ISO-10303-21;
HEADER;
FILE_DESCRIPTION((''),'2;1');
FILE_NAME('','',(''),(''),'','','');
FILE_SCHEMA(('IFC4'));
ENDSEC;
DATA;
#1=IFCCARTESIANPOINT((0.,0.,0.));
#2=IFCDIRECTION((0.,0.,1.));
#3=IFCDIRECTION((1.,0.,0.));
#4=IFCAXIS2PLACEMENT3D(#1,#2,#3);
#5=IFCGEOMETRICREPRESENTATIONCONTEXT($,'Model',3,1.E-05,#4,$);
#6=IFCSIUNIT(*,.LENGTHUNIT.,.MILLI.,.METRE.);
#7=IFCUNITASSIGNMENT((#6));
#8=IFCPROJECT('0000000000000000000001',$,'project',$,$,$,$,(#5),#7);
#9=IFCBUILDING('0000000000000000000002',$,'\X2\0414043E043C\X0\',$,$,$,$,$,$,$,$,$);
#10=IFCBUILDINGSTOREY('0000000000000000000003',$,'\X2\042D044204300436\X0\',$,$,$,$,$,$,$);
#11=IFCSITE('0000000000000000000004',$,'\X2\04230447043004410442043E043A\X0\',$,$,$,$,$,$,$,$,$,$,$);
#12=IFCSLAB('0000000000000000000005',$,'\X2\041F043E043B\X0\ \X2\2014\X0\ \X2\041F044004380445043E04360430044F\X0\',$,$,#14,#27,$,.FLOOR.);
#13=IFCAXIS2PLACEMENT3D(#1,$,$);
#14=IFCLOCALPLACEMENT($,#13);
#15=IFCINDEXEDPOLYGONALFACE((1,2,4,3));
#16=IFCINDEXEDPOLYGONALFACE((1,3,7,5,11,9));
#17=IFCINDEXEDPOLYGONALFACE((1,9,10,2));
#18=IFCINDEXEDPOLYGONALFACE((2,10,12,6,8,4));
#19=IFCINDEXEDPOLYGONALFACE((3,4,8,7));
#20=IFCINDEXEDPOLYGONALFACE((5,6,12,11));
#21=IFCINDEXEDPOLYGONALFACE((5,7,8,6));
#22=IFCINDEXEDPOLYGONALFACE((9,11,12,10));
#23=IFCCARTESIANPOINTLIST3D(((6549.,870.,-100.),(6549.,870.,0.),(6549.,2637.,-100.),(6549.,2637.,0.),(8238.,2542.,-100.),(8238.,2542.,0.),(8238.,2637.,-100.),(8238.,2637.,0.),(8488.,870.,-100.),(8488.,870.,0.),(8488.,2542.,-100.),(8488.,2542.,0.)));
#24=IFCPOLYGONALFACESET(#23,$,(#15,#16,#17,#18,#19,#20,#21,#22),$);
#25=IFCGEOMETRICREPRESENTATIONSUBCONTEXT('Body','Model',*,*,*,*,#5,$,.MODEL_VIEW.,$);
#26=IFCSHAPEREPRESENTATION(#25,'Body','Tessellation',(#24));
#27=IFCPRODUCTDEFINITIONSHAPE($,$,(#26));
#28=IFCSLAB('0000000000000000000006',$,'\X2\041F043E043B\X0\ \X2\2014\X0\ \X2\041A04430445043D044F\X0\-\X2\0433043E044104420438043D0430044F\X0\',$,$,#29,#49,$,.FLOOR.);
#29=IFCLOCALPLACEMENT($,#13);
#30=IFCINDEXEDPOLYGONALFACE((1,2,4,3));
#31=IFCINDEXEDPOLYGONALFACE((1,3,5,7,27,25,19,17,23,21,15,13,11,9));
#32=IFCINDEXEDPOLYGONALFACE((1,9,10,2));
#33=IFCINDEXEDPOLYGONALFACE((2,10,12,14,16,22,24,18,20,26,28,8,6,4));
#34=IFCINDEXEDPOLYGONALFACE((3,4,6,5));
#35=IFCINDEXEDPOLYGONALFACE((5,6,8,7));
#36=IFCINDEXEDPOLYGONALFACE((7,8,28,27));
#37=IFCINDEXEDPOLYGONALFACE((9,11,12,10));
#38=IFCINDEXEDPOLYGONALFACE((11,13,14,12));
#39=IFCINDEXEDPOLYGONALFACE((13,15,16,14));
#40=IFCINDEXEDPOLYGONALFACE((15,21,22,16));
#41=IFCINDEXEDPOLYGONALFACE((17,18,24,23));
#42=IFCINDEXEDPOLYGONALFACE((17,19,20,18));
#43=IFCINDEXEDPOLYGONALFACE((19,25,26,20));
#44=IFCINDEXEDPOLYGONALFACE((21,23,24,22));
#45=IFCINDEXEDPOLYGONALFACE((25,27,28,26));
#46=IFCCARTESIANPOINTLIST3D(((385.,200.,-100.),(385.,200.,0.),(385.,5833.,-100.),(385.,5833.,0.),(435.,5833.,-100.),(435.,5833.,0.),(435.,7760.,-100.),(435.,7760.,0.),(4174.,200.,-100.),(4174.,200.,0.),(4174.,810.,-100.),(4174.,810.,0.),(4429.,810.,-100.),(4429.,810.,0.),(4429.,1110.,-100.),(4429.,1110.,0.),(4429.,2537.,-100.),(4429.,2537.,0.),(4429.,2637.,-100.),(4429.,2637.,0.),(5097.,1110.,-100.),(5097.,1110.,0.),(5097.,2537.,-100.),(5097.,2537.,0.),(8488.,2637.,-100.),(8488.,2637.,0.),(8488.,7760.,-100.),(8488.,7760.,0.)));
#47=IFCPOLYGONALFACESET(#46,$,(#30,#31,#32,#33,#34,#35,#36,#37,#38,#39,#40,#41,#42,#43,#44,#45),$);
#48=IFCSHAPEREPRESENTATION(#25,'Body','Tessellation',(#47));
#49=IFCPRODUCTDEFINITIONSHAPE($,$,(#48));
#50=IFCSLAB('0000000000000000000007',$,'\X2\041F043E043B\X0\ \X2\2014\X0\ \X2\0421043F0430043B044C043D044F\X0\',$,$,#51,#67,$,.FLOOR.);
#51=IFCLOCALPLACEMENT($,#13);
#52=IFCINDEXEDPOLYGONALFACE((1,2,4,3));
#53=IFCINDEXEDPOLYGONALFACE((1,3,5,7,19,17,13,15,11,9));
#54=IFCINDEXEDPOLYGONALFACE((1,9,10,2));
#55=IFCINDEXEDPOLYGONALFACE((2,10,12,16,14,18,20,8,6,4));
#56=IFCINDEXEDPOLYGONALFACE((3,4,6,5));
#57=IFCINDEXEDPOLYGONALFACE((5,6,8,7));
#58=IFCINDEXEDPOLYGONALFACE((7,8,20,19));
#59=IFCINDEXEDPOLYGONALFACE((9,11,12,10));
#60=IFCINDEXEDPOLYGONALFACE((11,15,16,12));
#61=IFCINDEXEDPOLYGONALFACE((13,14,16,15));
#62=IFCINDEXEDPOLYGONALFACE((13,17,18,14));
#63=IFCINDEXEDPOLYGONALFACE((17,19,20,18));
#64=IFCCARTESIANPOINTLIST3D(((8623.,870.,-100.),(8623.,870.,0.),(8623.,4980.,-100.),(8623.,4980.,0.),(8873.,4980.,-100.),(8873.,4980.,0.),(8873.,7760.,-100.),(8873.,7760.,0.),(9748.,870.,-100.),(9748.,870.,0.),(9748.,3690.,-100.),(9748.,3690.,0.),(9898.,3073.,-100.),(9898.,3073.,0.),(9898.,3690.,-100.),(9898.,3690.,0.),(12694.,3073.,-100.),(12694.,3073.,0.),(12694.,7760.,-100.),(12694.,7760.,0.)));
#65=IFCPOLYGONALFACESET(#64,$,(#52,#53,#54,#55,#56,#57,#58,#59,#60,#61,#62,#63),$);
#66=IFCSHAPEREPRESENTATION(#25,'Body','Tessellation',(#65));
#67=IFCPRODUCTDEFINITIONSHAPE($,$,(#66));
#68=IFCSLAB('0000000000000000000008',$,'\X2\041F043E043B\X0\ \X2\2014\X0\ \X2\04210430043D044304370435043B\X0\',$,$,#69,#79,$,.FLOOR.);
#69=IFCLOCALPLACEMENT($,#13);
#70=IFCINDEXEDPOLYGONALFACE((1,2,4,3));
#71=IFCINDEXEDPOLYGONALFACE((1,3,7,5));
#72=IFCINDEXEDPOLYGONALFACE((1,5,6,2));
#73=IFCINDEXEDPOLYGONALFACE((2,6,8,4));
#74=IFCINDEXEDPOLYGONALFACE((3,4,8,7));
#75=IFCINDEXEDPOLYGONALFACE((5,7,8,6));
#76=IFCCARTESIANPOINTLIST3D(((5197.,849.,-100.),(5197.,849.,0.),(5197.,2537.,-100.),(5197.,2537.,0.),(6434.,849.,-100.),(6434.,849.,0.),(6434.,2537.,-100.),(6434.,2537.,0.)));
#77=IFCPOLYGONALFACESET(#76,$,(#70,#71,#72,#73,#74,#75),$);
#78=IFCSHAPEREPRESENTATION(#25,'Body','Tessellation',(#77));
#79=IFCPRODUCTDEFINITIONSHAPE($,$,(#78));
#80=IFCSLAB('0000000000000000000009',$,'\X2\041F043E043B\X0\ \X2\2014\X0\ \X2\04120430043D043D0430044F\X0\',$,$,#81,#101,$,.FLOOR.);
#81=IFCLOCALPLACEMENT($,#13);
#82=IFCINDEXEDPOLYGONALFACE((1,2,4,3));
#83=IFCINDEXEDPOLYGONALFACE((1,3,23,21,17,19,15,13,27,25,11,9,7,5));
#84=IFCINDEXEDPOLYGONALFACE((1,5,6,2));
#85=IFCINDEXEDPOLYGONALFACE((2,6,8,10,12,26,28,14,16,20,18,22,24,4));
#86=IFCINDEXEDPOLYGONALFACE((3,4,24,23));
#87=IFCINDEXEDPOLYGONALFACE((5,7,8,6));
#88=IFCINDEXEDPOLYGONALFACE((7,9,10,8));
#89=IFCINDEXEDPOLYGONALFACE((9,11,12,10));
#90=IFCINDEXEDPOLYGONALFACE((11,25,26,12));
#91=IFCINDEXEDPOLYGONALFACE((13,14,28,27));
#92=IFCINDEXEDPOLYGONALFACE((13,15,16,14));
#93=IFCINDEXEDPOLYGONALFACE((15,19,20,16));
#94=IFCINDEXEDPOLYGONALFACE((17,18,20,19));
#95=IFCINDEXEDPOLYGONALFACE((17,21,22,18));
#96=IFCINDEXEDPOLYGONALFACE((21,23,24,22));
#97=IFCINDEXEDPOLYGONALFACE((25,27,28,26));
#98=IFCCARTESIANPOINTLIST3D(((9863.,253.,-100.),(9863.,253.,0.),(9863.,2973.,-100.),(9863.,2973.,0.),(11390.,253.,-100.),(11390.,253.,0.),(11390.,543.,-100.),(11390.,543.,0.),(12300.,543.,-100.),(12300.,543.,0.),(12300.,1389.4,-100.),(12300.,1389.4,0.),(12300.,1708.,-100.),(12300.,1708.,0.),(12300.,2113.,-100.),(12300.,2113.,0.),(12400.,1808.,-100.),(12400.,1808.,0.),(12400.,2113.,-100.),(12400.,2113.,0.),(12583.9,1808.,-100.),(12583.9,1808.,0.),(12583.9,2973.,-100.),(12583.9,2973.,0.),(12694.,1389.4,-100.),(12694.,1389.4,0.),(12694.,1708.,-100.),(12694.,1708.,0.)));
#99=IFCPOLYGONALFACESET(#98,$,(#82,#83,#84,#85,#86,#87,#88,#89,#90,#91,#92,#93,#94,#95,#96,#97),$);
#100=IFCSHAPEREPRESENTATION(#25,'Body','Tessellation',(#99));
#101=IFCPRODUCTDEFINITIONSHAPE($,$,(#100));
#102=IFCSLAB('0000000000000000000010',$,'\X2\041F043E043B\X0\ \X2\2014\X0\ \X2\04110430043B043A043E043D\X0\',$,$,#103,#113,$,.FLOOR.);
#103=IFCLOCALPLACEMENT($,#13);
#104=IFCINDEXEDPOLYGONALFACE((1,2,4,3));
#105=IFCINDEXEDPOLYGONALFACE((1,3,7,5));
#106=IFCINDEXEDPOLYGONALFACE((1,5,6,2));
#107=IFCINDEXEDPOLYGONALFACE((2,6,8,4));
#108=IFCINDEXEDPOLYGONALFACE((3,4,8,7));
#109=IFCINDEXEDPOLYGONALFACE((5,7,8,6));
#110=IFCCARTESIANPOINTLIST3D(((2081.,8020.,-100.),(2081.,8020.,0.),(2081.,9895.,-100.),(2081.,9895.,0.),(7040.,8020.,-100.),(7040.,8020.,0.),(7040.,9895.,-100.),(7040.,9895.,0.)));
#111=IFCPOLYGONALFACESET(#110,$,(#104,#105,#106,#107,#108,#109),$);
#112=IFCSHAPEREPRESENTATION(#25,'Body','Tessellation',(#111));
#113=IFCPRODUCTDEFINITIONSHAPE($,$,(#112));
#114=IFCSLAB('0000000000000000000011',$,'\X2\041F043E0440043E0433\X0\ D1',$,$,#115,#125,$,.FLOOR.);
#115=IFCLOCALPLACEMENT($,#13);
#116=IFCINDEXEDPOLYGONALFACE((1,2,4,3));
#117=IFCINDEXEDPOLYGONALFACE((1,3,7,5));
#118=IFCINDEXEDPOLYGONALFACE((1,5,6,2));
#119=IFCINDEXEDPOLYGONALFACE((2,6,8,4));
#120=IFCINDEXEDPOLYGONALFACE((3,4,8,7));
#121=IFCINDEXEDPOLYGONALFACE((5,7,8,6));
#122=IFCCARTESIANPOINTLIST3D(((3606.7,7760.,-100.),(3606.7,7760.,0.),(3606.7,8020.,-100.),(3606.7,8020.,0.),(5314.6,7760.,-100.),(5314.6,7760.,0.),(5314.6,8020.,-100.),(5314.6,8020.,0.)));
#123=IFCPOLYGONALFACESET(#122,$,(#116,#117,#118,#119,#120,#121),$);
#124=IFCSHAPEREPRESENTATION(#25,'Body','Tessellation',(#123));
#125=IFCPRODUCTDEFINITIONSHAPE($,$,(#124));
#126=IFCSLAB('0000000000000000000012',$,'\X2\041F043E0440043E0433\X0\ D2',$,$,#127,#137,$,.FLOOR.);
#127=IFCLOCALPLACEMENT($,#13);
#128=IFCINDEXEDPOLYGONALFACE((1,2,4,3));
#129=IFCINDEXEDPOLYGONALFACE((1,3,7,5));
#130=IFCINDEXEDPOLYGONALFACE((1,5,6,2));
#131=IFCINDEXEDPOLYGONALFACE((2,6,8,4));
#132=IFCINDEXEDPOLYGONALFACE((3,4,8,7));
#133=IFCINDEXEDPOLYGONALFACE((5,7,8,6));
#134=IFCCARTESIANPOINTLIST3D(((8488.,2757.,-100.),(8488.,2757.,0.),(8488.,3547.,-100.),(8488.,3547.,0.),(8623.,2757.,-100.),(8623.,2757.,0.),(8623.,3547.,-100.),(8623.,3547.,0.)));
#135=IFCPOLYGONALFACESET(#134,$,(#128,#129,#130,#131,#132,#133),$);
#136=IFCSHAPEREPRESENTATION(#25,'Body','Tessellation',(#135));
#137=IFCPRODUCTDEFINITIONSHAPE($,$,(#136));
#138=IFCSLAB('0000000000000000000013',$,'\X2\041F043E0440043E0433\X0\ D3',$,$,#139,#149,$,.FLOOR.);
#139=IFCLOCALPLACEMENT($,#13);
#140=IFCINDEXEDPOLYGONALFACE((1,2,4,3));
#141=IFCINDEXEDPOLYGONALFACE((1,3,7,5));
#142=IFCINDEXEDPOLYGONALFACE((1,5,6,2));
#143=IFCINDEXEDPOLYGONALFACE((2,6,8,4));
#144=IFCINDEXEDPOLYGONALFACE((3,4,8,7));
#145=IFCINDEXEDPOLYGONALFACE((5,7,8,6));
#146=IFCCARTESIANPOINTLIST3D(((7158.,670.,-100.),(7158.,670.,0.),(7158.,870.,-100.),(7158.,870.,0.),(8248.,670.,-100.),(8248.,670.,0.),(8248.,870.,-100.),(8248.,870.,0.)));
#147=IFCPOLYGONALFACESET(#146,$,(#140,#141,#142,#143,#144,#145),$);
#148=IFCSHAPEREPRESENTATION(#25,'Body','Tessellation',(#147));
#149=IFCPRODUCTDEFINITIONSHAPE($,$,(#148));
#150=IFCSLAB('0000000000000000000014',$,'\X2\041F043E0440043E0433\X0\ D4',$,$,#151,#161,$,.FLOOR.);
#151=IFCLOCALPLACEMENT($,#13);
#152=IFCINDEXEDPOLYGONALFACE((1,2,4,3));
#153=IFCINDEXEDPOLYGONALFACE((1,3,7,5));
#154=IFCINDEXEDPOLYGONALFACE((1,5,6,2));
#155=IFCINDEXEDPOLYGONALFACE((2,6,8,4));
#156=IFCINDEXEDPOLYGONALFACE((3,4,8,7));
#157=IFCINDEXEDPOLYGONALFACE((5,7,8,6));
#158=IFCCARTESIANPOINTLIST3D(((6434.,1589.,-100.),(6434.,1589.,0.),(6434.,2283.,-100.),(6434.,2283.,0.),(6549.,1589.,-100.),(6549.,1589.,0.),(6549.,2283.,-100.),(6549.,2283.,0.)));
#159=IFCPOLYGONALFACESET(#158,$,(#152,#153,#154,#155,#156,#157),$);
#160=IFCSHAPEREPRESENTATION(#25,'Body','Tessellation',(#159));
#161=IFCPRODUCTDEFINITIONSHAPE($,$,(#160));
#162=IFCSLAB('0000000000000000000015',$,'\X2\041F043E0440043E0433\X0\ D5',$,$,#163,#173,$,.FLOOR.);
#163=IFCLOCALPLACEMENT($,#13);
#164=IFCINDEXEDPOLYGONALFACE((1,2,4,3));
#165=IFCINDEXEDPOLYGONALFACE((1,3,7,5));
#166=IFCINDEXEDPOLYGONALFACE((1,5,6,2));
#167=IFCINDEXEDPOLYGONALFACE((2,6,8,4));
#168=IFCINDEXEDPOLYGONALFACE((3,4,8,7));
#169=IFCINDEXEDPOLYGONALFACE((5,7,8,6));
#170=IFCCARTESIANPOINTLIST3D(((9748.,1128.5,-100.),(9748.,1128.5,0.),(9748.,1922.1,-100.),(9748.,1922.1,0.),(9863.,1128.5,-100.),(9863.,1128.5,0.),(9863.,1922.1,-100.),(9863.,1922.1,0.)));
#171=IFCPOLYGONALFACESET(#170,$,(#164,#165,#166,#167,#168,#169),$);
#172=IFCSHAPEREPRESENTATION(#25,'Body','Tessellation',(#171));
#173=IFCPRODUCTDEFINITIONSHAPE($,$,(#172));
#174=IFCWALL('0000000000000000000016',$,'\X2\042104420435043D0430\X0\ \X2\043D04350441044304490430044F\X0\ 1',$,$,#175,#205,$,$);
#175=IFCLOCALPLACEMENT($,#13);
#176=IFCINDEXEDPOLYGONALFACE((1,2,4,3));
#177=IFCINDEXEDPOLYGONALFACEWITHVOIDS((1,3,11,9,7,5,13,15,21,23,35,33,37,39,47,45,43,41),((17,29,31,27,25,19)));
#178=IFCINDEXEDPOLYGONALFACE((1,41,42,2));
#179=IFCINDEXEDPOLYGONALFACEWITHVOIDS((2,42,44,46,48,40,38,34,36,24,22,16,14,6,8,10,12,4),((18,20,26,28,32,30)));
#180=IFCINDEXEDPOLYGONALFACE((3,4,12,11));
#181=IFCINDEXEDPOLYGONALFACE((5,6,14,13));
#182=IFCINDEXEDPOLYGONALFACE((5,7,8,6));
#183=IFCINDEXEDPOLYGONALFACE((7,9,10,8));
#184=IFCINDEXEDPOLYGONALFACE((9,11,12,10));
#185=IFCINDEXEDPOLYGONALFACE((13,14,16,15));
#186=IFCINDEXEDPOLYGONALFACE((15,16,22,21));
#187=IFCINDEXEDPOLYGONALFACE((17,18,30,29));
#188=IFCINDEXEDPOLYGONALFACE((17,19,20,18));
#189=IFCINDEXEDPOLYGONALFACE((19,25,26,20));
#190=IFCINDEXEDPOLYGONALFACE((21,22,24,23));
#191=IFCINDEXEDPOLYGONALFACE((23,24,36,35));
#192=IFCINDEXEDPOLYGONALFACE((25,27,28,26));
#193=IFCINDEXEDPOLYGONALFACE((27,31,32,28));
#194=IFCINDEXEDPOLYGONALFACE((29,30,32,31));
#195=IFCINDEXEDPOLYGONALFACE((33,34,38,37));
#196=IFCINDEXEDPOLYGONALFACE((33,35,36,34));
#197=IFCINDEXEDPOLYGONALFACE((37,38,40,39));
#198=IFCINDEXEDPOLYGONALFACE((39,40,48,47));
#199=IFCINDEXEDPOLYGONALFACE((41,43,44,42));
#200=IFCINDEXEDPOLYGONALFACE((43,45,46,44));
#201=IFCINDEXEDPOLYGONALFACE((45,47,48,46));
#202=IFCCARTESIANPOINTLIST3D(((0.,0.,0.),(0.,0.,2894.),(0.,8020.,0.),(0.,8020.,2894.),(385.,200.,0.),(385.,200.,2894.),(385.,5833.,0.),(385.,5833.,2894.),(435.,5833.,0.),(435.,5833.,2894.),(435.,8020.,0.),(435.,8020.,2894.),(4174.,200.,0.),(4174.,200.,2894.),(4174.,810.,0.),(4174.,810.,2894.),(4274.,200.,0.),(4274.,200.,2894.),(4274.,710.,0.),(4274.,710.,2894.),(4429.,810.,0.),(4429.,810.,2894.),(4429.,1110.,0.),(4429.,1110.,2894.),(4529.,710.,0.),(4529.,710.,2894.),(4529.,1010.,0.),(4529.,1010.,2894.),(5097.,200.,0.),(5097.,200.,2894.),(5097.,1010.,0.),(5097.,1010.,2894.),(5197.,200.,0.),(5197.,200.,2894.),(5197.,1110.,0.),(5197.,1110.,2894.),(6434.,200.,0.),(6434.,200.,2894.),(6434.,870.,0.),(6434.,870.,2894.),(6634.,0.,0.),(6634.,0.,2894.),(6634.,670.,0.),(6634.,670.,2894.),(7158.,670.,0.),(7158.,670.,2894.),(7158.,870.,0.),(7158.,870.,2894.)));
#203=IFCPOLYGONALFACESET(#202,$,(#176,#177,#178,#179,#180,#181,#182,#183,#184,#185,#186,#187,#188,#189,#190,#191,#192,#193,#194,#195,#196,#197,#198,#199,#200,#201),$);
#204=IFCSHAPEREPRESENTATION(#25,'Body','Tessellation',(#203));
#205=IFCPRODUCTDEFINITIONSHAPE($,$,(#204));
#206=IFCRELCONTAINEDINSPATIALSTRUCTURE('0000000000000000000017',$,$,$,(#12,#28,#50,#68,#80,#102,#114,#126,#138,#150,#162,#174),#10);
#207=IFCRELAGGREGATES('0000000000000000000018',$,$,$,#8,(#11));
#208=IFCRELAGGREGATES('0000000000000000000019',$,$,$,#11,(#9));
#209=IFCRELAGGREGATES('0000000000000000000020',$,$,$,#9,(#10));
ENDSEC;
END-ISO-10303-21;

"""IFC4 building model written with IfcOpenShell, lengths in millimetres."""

from ifc_helpers import new_model, si_unit, frame, origin, origin_with_axes, place, context, subcontext, project, spatial, polyline, outline, extrude, element, save


model = new_model("IFC4")

# Units and contexts
model_context = context("Model", 3, precision=1e-05, world=origin_with_axes())
body_context = subcontext(model_context, "Body", "Model", "MODEL_VIEW")
ifc_project = project(units=[si_unit("LENGTHUNIT", "METRE", prefix="MILLI")], contexts=[model_context])

# Site, building, storey
site = spatial("IfcSite", under=ifc_project, Name="Участок")
building = spatial("IfcBuilding", under=site, Name="Дом")
storey = spatial("IfcBuildingStorey", under=building, Name="Этаж")

# Slabs
slab_1_placement = place(None, frame((0.0, 0.0, -100.0), z_axis=(0.0, 0.0, 1.0), x_axis=(1.0, 0.0, 0.0)))
element("IfcSlab", 1, at=slab_1_placement, inside=storey, Name="Пол — Прихожая", PredefinedType="FLOOR", context=body_context, shape_type="SweptSolid", body=[
    extrude(outline(polyline([(8238.0, 2637.0), (8238.0, 2542.0), (8488.0, 2542.0), (8488.0, 870.0), (6549.0, 870.0), (6549.0, 2637.0), (8238.0, 2637.0)])), origin(), (0.0, 0.0, 1.0), 100.0),
])
slab_2_placement = place(None, frame((0.0, 0.0, -100.0), z_axis=(0.0, 0.0, 1.0), x_axis=(1.0, 0.0, 0.0)))
element("IfcSlab", 2, at=slab_2_placement, inside=storey, Name="Пол — Кухня-гостиная", PredefinedType="FLOOR", context=body_context, shape_type="SweptSolid", body=[
    extrude(outline(polyline([(435.0, 7760.0), (8488.0, 7760.0), (8488.0, 2637.0), (4429.0, 2637.0), (4429.0, 2537.0), (5097.0, 2537.0), (5097.0, 1110.0), (4429.0, 1110.0), (4429.0, 810.0), (4174.0, 810.0), (4174.0, 200.0), (385.0, 200.0), (385.0, 5833.0), (435.0, 5833.0), (435.0, 7760.0)])), origin(), (0.0, 0.0, 1.0), 100.0),
])
slab_3_placement = place(None, frame((0.0, 0.0, -100.0), z_axis=(0.0, 0.0, 1.0), x_axis=(1.0, 0.0, 0.0)))
element("IfcSlab", 3, at=slab_3_placement, inside=storey, Name="Пол — Спальня", PredefinedType="FLOOR", context=body_context, shape_type="SweptSolid", body=[
    extrude(outline(polyline([(9748.0, 3690.0), (9748.0, 870.0), (8623.0, 870.0), (8623.0, 4980.0), (8873.0, 4980.0), (8873.0, 7760.0), (12694.0, 7760.0), (12694.0, 3073.0), (9898.0, 3073.0), (9898.0, 3690.0), (9748.0, 3690.0)])), origin(), (0.0, 0.0, 1.0), 100.0),
])
slab_4_placement = place(None, frame((0.0, 0.0, -100.0), z_axis=(0.0, 0.0, 1.0), x_axis=(1.0, 0.0, 0.0)))
element("IfcSlab", 4, at=slab_4_placement, inside=storey, Name="Пол — Санузел", PredefinedType="FLOOR", context=body_context, shape_type="SweptSolid", body=[
    extrude(outline(polyline([(5197.0, 2537.0), (6434.0, 2537.0), (6434.0, 849.0), (5197.0, 849.0), (5197.0, 2537.0)])), origin(), (0.0, 0.0, 1.0), 100.0),
])
slab_5_placement = place(None, frame((0.0, 0.0, -100.0), z_axis=(0.0, 0.0, 1.0), x_axis=(1.0, 0.0, 0.0)))
element("IfcSlab", 5, at=slab_5_placement, inside=storey, Name="Пол — Ванная", PredefinedType="FLOOR", context=body_context, shape_type="SweptSolid", body=[
    extrude(outline(polyline([(9863.0, 253.0), (9863.0, 2973.0), (12583.9, 2973.0), (12583.9, 1808.0), (12400.0, 1808.0), (12400.0, 2113.0), (12300.0, 2113.0), (12300.0, 1708.0), (12694.0, 1708.0), (12694.0, 1389.4), (12300.0, 1389.4), (12300.0, 543.0), (11390.0, 543.0), (11390.0, 253.0), (9863.0, 253.0)])), origin(), (0.0, 0.0, 1.0), 100.0),
])
slab_6_placement = place(None, frame((0.0, 0.0, -100.0), z_axis=(0.0, 0.0, 1.0), x_axis=(1.0, 0.0, 0.0)))
element("IfcSlab", 6, at=slab_6_placement, inside=storey, Name="Пол — Балкон", PredefinedType="FLOOR", context=body_context, shape_type="SweptSolid", body=[
    extrude(outline(polyline([(2081.0, 8020.0), (2081.0, 9895.0), (7040.0, 9895.0), (7040.0, 8020.0), (2081.0, 8020.0)])), origin(), (0.0, 0.0, 1.0), 100.0),
])
slab_7_placement = place(None, frame((0.0, 0.0, -100.0), z_axis=(0.0, 0.0, 1.0), x_axis=(1.0, 0.0, 0.0)))
element("IfcSlab", 7, at=slab_7_placement, inside=storey, Name="Порог D1", PredefinedType="FLOOR", context=body_context, shape_type="SweptSolid", body=[
    extrude(outline(polyline([(5314.6, 7760.0), (3606.7, 7760.0), (3606.7, 8020.0), (5314.6, 8020.0), (5314.6, 7760.0)])), origin(), (0.0, 0.0, 1.0), 100.0),
])
slab_8_placement = place(None, frame((0.0, 0.0, -100.0), z_axis=(0.0, 0.0, 1.0), x_axis=(1.0, 0.0, 0.0)))
element("IfcSlab", 8, at=slab_8_placement, inside=storey, Name="Порог D2", PredefinedType="FLOOR", context=body_context, shape_type="SweptSolid", body=[
    extrude(outline(polyline([(8488.0, 3547.0), (8623.0, 3547.0), (8623.0, 2757.0), (8488.0, 2757.0), (8488.0, 3547.0)])), origin(), (0.0, 0.0, 1.0), 100.0),
])
slab_9_placement = place(None, frame((0.0, 0.0, -100.0), z_axis=(0.0, 0.0, 1.0), x_axis=(1.0, 0.0, 0.0)))
element("IfcSlab", 9, at=slab_9_placement, inside=storey, Name="Порог D3", PredefinedType="FLOOR", context=body_context, shape_type="SweptSolid", body=[
    extrude(outline(polyline([(7158.0, 670.0), (7158.0, 870.0), (8248.0, 870.0), (8248.0, 670.0), (7158.0, 670.0)])), origin(), (0.0, 0.0, 1.0), 100.0),
])
slab_10_placement = place(None, frame((0.0, 0.0, -100.0), z_axis=(0.0, 0.0, 1.0), x_axis=(1.0, 0.0, 0.0)))
element("IfcSlab", 10, at=slab_10_placement, inside=storey, Name="Порог D4", PredefinedType="FLOOR", context=body_context, shape_type="SweptSolid", body=[
    extrude(outline(polyline([(6549.0, 2283.0), (6549.0, 1589.0), (6434.0, 1589.0), (6434.0, 2283.0), (6549.0, 2283.0)])), origin(), (0.0, 0.0, 1.0), 100.0),
])
slab_11_placement = place(None, frame((0.0, 0.0, -100.0), z_axis=(0.0, 0.0, 1.0), x_axis=(1.0, 0.0, 0.0)))
element("IfcSlab", 11, at=slab_11_placement, inside=storey, Name="Порог D5", PredefinedType="FLOOR", context=body_context, shape_type="SweptSolid", body=[
    extrude(outline(polyline([(9748.0, 1922.1), (9748.0, 1128.5), (9863.0, 1128.5), (9863.0, 1922.1), (9748.0, 1922.1)])), origin(), (0.0, 0.0, 1.0), 100.0),
])

# Wall
wall_1_placement = place(None, origin_with_axes())
element("IfcWall", 12, at=wall_1_placement, inside=storey, Name="Стена несущая 1", context=body_context, shape_type="SweptSolid", body=[
    extrude(outline(polyline([(4174.0, 810.0), (4429.0, 810.0), (4429.0, 1110.0), (5197.0, 1110.0), (5197.0, 200.0), (6434.0, 200.0), (6434.0, 870.0), (7158.0, 870.0), (7158.0, 670.0), (6634.0, 670.0), (6634.0, 0.0), (0.0, 0.0), (0.0, 8020.0), (435.0, 8020.0), (435.0, 5833.0), (385.0, 5833.0), (385.0, 200.0), (4174.0, 200.0), (4174.0, 810.0)]), holes=[polyline([(4529.0, 710.0), (4274.0, 710.0), (4274.0, 200.0), (5097.0, 200.0), (5097.0, 1010.0), (4529.0, 1010.0), (4529.0, 710.0)])]), origin(), (0.0, 0.0, 1.0), 2894.0),
])

save(model, "model.ifc")
